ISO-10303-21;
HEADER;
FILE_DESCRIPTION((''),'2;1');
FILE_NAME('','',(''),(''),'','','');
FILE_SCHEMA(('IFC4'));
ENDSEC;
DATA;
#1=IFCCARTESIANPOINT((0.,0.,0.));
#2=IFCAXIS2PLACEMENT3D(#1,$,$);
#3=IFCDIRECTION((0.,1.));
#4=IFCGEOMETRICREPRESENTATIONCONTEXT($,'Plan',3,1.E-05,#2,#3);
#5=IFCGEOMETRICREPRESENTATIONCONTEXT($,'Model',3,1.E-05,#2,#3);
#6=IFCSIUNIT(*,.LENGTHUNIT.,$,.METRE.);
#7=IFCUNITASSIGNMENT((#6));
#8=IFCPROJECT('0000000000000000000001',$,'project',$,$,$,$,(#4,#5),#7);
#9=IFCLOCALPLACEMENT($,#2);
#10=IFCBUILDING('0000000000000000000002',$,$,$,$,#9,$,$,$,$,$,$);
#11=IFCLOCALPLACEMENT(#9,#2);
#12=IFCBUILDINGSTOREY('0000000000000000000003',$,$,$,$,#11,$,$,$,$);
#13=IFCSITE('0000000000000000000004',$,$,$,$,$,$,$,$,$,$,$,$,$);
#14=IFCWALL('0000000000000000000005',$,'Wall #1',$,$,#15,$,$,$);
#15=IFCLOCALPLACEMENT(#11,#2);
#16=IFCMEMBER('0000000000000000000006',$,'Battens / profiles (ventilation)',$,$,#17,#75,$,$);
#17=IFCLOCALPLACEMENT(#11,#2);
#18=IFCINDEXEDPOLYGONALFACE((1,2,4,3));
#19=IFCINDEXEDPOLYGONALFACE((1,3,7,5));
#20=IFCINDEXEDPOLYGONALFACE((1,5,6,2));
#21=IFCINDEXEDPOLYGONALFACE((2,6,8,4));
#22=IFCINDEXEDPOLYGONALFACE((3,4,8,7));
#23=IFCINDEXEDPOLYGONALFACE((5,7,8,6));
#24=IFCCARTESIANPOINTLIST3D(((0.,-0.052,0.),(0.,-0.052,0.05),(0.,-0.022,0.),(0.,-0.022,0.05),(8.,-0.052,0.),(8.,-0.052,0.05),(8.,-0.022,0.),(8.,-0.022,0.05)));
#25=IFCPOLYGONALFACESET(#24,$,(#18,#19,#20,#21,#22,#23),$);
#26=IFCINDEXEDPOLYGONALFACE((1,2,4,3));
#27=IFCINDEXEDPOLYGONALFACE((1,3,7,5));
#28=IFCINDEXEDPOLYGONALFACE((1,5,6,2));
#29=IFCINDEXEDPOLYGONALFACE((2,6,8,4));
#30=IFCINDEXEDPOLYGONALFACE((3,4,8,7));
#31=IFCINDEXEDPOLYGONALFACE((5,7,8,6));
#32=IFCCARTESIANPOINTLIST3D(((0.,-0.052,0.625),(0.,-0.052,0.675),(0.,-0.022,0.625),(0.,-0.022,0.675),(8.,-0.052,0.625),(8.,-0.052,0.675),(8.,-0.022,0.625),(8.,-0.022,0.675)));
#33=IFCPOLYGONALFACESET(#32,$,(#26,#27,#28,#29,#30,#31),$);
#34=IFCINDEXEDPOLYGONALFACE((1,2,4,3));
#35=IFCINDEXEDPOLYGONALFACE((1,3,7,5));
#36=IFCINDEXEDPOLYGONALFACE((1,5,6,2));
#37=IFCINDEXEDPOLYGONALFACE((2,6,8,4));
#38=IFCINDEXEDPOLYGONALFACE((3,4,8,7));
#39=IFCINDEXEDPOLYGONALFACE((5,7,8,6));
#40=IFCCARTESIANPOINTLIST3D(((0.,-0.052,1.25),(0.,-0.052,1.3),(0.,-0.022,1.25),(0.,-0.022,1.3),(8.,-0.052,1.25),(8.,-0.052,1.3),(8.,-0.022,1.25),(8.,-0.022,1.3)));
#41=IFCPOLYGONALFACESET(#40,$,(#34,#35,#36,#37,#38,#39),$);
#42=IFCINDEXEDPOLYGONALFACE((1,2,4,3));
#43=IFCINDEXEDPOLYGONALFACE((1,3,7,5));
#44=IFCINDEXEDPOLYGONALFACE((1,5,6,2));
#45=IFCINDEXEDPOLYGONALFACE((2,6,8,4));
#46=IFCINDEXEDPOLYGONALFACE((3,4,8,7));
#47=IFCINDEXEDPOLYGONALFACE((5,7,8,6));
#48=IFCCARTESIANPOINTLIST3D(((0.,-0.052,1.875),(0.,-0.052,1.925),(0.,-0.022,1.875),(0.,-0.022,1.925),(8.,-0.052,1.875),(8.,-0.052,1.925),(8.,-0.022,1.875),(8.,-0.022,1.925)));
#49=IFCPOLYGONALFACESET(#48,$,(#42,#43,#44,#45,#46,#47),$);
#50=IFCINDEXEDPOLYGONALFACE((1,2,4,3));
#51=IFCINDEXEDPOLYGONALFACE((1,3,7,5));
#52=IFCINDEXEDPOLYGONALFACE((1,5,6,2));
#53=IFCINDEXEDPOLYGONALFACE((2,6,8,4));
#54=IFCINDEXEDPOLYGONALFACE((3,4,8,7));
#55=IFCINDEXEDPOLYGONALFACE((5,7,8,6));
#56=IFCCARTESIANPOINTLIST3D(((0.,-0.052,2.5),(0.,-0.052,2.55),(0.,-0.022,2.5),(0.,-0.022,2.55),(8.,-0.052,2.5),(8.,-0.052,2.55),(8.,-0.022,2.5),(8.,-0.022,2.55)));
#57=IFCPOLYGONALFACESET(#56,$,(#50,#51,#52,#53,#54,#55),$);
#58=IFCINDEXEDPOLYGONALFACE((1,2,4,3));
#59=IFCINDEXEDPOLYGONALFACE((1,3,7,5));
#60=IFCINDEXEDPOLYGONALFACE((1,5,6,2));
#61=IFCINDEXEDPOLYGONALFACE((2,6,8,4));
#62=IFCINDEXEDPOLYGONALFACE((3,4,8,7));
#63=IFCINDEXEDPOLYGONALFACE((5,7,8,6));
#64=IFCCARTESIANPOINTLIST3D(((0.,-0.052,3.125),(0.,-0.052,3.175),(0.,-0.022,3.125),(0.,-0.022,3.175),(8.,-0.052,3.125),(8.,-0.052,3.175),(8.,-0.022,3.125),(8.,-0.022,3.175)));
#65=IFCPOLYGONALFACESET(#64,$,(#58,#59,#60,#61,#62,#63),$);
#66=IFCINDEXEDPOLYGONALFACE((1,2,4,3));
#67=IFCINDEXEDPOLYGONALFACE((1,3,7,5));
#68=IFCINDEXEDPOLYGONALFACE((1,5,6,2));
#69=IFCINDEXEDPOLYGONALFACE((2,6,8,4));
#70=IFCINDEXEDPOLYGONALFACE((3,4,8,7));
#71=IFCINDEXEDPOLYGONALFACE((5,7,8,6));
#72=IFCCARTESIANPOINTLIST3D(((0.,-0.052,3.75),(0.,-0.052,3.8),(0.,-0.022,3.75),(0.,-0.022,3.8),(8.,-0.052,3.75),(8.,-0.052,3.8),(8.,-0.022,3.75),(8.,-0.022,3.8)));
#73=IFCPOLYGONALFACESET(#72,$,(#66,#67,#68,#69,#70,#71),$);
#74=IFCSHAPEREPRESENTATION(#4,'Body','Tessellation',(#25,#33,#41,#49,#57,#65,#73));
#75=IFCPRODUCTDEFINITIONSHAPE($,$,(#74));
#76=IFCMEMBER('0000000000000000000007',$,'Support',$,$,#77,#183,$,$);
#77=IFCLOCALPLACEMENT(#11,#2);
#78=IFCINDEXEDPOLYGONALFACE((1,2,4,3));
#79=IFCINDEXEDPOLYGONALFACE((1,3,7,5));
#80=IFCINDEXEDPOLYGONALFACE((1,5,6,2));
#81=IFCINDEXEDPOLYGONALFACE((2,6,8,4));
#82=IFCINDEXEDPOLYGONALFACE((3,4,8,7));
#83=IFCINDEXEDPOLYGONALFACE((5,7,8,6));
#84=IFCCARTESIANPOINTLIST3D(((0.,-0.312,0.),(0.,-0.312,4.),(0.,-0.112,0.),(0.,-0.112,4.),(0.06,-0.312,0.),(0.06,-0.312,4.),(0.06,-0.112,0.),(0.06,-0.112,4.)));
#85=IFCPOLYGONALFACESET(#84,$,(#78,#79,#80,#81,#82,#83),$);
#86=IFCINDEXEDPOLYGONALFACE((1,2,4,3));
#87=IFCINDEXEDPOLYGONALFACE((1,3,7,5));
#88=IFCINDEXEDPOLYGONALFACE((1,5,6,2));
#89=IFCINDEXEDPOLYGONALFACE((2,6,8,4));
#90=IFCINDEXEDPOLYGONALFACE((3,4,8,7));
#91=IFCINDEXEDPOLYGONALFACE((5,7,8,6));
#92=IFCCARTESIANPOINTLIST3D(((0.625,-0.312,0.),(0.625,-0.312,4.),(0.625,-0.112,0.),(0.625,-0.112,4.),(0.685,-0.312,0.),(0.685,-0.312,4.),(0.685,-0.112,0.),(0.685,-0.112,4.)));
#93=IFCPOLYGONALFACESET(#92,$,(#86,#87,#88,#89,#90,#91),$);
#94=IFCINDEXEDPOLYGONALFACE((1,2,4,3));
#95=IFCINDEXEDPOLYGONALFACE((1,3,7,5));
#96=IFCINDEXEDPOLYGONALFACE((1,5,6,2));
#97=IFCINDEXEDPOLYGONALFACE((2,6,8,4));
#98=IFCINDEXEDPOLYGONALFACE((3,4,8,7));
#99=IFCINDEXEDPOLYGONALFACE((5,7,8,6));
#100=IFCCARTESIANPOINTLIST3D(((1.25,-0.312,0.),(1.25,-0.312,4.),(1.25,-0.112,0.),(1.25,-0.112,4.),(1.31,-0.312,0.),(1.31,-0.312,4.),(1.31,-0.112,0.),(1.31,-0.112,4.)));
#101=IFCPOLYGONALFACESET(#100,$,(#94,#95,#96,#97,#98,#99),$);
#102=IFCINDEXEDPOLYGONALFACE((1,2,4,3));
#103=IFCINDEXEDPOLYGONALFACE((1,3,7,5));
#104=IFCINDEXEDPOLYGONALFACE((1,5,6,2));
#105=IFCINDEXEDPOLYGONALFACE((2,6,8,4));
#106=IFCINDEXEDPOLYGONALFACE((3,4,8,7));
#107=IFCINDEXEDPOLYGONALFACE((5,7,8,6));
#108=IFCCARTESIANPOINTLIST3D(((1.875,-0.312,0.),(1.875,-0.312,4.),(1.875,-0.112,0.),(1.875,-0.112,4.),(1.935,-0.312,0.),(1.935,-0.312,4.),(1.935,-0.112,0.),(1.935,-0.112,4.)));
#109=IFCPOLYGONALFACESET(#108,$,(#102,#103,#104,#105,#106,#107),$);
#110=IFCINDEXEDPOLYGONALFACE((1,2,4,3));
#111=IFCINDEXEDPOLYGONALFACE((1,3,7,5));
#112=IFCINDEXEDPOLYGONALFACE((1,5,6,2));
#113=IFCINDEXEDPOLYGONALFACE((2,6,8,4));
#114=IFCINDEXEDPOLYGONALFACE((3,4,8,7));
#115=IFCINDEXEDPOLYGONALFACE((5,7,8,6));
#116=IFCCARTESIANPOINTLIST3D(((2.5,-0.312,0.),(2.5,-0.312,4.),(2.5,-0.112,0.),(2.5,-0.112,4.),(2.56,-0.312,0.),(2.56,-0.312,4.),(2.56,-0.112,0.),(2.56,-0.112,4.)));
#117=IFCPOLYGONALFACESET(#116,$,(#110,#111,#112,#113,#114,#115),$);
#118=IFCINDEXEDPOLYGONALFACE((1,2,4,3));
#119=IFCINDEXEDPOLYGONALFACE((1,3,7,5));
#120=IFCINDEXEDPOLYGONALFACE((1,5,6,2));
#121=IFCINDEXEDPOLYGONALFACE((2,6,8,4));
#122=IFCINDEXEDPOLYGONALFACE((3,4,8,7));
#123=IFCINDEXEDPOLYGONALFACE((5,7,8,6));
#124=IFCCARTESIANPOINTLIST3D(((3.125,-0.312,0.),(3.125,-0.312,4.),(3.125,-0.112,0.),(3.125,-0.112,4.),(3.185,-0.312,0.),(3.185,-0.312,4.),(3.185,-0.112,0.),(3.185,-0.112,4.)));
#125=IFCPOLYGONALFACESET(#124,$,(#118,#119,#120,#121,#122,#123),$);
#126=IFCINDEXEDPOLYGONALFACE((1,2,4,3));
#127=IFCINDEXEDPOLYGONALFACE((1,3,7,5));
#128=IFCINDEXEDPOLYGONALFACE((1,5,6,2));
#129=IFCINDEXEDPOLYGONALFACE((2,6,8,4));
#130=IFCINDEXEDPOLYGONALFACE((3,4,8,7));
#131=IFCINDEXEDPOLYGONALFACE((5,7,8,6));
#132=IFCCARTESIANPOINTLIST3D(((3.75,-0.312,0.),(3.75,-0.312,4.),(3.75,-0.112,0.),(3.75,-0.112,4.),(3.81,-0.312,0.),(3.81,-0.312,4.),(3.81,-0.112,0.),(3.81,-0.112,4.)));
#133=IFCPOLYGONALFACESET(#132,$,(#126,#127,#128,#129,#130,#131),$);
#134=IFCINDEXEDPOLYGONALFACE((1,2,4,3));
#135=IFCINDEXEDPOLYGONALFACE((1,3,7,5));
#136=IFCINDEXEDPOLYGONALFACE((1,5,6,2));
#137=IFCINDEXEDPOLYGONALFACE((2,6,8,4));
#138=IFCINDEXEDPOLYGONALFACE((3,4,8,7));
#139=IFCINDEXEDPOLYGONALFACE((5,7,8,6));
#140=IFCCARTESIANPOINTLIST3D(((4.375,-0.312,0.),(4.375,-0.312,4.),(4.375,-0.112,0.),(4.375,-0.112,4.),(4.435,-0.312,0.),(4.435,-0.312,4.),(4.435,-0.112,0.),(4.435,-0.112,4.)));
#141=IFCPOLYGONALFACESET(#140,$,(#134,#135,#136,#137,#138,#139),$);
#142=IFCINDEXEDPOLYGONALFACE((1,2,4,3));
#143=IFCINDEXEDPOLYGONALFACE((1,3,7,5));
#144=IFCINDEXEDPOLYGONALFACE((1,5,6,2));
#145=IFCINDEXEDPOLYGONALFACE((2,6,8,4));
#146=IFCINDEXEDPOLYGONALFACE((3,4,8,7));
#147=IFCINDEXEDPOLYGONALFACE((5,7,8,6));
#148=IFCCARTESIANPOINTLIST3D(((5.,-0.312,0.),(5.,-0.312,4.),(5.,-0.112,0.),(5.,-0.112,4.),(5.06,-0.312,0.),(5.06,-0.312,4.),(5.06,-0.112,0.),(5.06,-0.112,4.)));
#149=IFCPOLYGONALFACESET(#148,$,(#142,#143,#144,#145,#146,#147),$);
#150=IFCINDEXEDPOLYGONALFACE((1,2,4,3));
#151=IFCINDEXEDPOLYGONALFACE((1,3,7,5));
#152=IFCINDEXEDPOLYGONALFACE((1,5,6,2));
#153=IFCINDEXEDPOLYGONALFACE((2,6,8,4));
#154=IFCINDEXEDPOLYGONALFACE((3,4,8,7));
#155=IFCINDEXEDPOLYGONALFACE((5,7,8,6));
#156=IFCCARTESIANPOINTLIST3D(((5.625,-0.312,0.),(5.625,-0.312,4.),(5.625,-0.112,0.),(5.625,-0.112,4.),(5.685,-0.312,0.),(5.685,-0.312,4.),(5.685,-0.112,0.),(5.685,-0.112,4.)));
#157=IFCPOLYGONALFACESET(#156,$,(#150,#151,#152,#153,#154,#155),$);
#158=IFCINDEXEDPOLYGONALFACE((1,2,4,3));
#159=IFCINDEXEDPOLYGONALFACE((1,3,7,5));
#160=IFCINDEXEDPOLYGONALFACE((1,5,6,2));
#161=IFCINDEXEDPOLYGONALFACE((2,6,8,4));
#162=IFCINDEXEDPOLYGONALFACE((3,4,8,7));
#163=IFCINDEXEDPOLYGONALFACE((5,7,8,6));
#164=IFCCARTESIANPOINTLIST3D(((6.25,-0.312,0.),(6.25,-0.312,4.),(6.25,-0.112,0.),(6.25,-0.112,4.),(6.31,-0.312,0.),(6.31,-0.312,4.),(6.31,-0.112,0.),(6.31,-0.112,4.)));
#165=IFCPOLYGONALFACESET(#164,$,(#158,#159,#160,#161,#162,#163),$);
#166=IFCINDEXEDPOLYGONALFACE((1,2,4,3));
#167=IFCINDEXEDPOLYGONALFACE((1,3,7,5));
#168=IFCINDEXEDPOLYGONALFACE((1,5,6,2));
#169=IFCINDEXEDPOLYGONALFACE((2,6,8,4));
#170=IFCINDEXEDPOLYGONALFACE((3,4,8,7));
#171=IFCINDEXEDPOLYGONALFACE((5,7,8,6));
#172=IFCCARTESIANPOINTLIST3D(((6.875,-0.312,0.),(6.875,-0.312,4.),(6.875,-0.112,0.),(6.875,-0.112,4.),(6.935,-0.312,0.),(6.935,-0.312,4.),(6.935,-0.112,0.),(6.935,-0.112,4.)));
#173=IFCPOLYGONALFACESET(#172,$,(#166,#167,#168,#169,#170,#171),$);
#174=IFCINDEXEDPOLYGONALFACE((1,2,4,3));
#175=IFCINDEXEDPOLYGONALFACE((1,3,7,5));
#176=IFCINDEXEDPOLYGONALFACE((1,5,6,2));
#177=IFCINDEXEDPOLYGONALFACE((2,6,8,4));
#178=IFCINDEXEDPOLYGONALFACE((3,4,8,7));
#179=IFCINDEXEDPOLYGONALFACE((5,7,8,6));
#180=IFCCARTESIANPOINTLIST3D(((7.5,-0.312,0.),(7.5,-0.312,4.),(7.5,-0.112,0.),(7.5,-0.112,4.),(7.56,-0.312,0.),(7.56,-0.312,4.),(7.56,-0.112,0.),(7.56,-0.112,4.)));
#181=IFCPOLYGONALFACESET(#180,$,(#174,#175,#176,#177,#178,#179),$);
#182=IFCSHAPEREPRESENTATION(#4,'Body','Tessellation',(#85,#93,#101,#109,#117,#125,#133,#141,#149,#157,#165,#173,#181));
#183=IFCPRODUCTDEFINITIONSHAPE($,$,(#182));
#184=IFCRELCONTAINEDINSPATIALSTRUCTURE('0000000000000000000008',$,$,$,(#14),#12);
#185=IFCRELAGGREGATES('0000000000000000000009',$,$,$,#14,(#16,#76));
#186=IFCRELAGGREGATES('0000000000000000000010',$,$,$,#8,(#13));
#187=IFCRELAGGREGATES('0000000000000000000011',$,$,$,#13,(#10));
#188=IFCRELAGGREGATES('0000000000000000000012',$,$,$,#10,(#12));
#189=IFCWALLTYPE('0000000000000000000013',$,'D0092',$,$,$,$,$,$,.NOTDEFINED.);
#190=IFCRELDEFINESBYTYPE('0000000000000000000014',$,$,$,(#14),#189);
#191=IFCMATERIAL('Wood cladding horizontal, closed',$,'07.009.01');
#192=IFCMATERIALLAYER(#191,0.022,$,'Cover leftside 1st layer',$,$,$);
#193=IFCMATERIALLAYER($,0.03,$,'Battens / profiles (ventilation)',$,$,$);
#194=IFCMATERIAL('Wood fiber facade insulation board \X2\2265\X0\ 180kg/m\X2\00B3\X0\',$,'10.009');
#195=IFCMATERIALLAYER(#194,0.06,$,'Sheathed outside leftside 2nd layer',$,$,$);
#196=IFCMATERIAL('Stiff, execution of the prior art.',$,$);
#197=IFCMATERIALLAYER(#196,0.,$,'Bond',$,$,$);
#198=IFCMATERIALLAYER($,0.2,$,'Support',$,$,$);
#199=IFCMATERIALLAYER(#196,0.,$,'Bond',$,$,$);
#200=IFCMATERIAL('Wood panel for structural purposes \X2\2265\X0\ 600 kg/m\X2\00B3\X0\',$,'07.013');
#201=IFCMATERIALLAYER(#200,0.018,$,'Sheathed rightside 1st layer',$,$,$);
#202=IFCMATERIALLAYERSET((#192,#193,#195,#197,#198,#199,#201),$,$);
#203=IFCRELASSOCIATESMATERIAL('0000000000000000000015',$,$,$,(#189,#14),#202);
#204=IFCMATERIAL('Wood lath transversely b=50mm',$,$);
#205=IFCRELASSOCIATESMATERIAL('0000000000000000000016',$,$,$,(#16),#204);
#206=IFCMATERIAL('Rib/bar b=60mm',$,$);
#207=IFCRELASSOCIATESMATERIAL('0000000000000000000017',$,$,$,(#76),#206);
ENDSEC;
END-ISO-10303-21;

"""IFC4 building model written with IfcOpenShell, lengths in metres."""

from ifc_helpers import new_model, si_unit, direction, frame, frame_2d, origin, place, context, project, spatial, rectangle, extrude, material, layer, layer_set, type_object, element, aggregate, save


model = new_model("IFC4")

# Units and contexts
plan_context = context("Plan", 3, precision=1e-05, world=origin(), true_north=direction((0.0, 1.0)))
model_context = context("Model", 3, precision=1e-05, world=origin(), true_north=direction((0.0, 1.0)))
ifc_project = project(units=[si_unit("LENGTHUNIT", "METRE")], contexts=[plan_context, model_context])

# Site, building, storey
site = spatial("IfcSite", under=ifc_project)
building_placement = place(None, origin())
building = spatial("IfcBuilding", under=site, at=building_placement)
storey_placement = place(building_placement, origin())
storey = spatial("IfcBuildingStorey", under=building, at=storey_placement)

# Wall, members
ifc_material_1 = material(Name="Wood cladding horizontal, closed", Category="07.009.01")
ifc_layer_1 = layer(ifc_material_1, 0.022, Name="Cover leftside 1st layer")
ifc_layer_2 = layer(None, 0.03, Name="Battens / profiles (ventilation)")
ifc_material_2 = material(Name="Wood fiber facade insulation board ≥ 180kg/m³", Category="10.009")
ifc_layer_3 = layer(ifc_material_2, 0.06, Name="Sheathed outside leftside 2nd layer")
ifc_material_3 = material(Name="Stiff, execution of the prior art.")
ifc_layer_4 = layer(ifc_material_3, 0.0, Name="Bond")
ifc_layer_5 = layer(None, 0.2, Name="Support")
ifc_layer_6 = layer(ifc_material_3, 0.0, Name="Bond")
ifc_material_4 = material(Name="Wood panel for structural purposes ≥ 600 kg/m³", Category="07.013")
ifc_layer_7 = layer(ifc_material_4, 0.018, Name="Sheathed rightside 1st layer")
ifc_layer_set = layer_set([ifc_layer_1, ifc_layer_2, ifc_layer_3, ifc_layer_4, ifc_layer_5, ifc_layer_6, ifc_layer_7])
wall_type = type_object("IfcWallType", Name="D0092", PredefinedType="NOTDEFINED", material=ifc_layer_set)
wall_placement = place(None, frame((0.0, 0.0, 0.0), z_axis=(0.0, -1.0, 0.0), x_axis=(1.0, 0.0, 0.0)))
wall = element("IfcWall", 1, at=wall_placement, inside=storey, type_object=wall_type, material=ifc_layer_set, Name="Wall #1")
ifc_material_5 = material(Name="Wood lath transversely b=50mm")
member_1_placement = place(wall_placement, origin())
member_1 = element("IfcMember", 2, at=member_1_placement, material=ifc_material_5, Name="Battens / profiles (ventilation)", context=plan_context, shape_type="SweptSolid", body=[
    extrude(rectangle(XDim=0.05, YDim=0.03, at=frame_2d((0.025, 0.015), x_axis=(1.0, 0.0))), frame((0.0, 0.0, 0.022), z_axis=(1.0, 0.0, 0.0), x_axis=(0.0, 1.0, 0.0)), (0.0, 0.0, 1.0), 8.0),
    extrude(rectangle(XDim=0.05, YDim=0.03, at=frame_2d((0.025, 0.015), x_axis=(1.0, 0.0))), frame((0.0, 0.625, 0.022), z_axis=(1.0, 0.0, 0.0), x_axis=(0.0, 1.0, 0.0)), (0.0, 0.0, 1.0), 8.0),
    extrude(rectangle(XDim=0.05, YDim=0.03, at=frame_2d((0.025, 0.015), x_axis=(1.0, 0.0))), frame((0.0, 1.25, 0.022), z_axis=(1.0, 0.0, 0.0), x_axis=(0.0, 1.0, 0.0)), (0.0, 0.0, 1.0), 8.0),
    extrude(rectangle(XDim=0.05, YDim=0.03, at=frame_2d((0.025, 0.015), x_axis=(1.0, 0.0))), frame((0.0, 1.875, 0.022), z_axis=(1.0, 0.0, 0.0), x_axis=(0.0, 1.0, 0.0)), (0.0, 0.0, 1.0), 8.0),
    extrude(rectangle(XDim=0.05, YDim=0.03, at=frame_2d((0.025, 0.015), x_axis=(1.0, 0.0))), frame((0.0, 2.5, 0.022), z_axis=(1.0, 0.0, 0.0), x_axis=(0.0, 1.0, 0.0)), (0.0, 0.0, 1.0), 8.0),
    extrude(rectangle(XDim=0.05, YDim=0.03, at=frame_2d((0.025, 0.015), x_axis=(1.0, 0.0))), frame((0.0, 3.125, 0.022), z_axis=(1.0, 0.0, 0.0), x_axis=(0.0, 1.0, 0.0)), (0.0, 0.0, 1.0), 8.0),
    extrude(rectangle(XDim=0.05, YDim=0.03, at=frame_2d((0.025, 0.015), x_axis=(1.0, 0.0))), frame((0.0, 3.75, 0.022), z_axis=(1.0, 0.0, 0.0), x_axis=(0.0, 1.0, 0.0)), (0.0, 0.0, 1.0), 8.0),
])
ifc_material_6 = material(Name="Rib/bar b=60mm")
member_2_placement = place(wall_placement, origin())
member_2 = element("IfcMember", 3, at=member_2_placement, material=ifc_material_6, Name="Support", context=plan_context, shape_type="SweptSolid", body=[
    extrude(rectangle(XDim=0.06, YDim=0.2, at=frame_2d((0.03, 0.1), x_axis=(1.0, 0.0))), frame((0.0, 4.0, 0.112), z_axis=(0.0, -1.0, 0.0), x_axis=(1.0, 0.0, 0.0)), (0.0, 0.0, 1.0), 4.0),
    extrude(rectangle(XDim=0.06, YDim=0.2, at=frame_2d((0.03, 0.1), x_axis=(1.0, 0.0))), frame((0.625, 4.0, 0.112), z_axis=(0.0, -1.0, 0.0), x_axis=(1.0, 0.0, 0.0)), (0.0, 0.0, 1.0), 4.0),
    extrude(rectangle(XDim=0.06, YDim=0.2, at=frame_2d((0.03, 0.1), x_axis=(1.0, 0.0))), frame((1.25, 4.0, 0.112), z_axis=(0.0, -1.0, 0.0), x_axis=(1.0, 0.0, 0.0)), (0.0, 0.0, 1.0), 4.0),
    extrude(rectangle(XDim=0.06, YDim=0.2, at=frame_2d((0.03, 0.1), x_axis=(1.0, 0.0))), frame((1.875, 4.0, 0.112), z_axis=(0.0, -1.0, 0.0), x_axis=(1.0, 0.0, 0.0)), (0.0, 0.0, 1.0), 4.0),
    extrude(rectangle(XDim=0.06, YDim=0.2, at=frame_2d((0.03, 0.1), x_axis=(1.0, 0.0))), frame((2.5, 4.0, 0.112), z_axis=(0.0, -1.0, 0.0), x_axis=(1.0, 0.0, 0.0)), (0.0, 0.0, 1.0), 4.0),
    extrude(rectangle(XDim=0.06, YDim=0.2, at=frame_2d((0.03, 0.1), x_axis=(1.0, 0.0))), frame((3.125, 4.0, 0.112), z_axis=(0.0, -1.0, 0.0), x_axis=(1.0, 0.0, 0.0)), (0.0, 0.0, 1.0), 4.0),
    extrude(rectangle(XDim=0.06, YDim=0.2, at=frame_2d((0.03, 0.1), x_axis=(1.0, 0.0))), frame((3.75, 4.0, 0.112), z_axis=(0.0, -1.0, 0.0), x_axis=(1.0, 0.0, 0.0)), (0.0, 0.0, 1.0), 4.0),
    extrude(rectangle(XDim=0.06, YDim=0.2, at=frame_2d((0.03, 0.1), x_axis=(1.0, 0.0))), frame((4.375, 4.0, 0.112), z_axis=(0.0, -1.0, 0.0), x_axis=(1.0, 0.0, 0.0)), (0.0, 0.0, 1.0), 4.0),
    extrude(rectangle(XDim=0.06, YDim=0.2, at=frame_2d((0.03, 0.1), x_axis=(1.0, 0.0))), frame((5.0, 4.0, 0.112), z_axis=(0.0, -1.0, 0.0), x_axis=(1.0, 0.0, 0.0)), (0.0, 0.0, 1.0), 4.0),
    extrude(rectangle(XDim=0.06, YDim=0.2, at=frame_2d((0.03, 0.1), x_axis=(1.0, 0.0))), frame((5.625, 4.0, 0.112), z_axis=(0.0, -1.0, 0.0), x_axis=(1.0, 0.0, 0.0)), (0.0, 0.0, 1.0), 4.0),
    extrude(rectangle(XDim=0.06, YDim=0.2, at=frame_2d((0.03, 0.1), x_axis=(1.0, 0.0))), frame((6.25, 4.0, 0.112), z_axis=(0.0, -1.0, 0.0), x_axis=(1.0, 0.0, 0.0)), (0.0, 0.0, 1.0), 4.0),
    extrude(rectangle(XDim=0.06, YDim=0.2, at=frame_2d((0.03, 0.1), x_axis=(1.0, 0.0))), frame((6.875, 4.0, 0.112), z_axis=(0.0, -1.0, 0.0), x_axis=(1.0, 0.0, 0.0)), (0.0, 0.0, 1.0), 4.0),
    extrude(rectangle(XDim=0.06, YDim=0.2, at=frame_2d((0.03, 0.1), x_axis=(1.0, 0.0))), frame((7.5, 4.0, 0.112), z_axis=(0.0, -1.0, 0.0), x_axis=(1.0, 0.0, 0.0)), (0.0, 0.0, 1.0), 4.0),
])
aggregate(wall, [member_1, member_2])

save(model, "model.ifc")
